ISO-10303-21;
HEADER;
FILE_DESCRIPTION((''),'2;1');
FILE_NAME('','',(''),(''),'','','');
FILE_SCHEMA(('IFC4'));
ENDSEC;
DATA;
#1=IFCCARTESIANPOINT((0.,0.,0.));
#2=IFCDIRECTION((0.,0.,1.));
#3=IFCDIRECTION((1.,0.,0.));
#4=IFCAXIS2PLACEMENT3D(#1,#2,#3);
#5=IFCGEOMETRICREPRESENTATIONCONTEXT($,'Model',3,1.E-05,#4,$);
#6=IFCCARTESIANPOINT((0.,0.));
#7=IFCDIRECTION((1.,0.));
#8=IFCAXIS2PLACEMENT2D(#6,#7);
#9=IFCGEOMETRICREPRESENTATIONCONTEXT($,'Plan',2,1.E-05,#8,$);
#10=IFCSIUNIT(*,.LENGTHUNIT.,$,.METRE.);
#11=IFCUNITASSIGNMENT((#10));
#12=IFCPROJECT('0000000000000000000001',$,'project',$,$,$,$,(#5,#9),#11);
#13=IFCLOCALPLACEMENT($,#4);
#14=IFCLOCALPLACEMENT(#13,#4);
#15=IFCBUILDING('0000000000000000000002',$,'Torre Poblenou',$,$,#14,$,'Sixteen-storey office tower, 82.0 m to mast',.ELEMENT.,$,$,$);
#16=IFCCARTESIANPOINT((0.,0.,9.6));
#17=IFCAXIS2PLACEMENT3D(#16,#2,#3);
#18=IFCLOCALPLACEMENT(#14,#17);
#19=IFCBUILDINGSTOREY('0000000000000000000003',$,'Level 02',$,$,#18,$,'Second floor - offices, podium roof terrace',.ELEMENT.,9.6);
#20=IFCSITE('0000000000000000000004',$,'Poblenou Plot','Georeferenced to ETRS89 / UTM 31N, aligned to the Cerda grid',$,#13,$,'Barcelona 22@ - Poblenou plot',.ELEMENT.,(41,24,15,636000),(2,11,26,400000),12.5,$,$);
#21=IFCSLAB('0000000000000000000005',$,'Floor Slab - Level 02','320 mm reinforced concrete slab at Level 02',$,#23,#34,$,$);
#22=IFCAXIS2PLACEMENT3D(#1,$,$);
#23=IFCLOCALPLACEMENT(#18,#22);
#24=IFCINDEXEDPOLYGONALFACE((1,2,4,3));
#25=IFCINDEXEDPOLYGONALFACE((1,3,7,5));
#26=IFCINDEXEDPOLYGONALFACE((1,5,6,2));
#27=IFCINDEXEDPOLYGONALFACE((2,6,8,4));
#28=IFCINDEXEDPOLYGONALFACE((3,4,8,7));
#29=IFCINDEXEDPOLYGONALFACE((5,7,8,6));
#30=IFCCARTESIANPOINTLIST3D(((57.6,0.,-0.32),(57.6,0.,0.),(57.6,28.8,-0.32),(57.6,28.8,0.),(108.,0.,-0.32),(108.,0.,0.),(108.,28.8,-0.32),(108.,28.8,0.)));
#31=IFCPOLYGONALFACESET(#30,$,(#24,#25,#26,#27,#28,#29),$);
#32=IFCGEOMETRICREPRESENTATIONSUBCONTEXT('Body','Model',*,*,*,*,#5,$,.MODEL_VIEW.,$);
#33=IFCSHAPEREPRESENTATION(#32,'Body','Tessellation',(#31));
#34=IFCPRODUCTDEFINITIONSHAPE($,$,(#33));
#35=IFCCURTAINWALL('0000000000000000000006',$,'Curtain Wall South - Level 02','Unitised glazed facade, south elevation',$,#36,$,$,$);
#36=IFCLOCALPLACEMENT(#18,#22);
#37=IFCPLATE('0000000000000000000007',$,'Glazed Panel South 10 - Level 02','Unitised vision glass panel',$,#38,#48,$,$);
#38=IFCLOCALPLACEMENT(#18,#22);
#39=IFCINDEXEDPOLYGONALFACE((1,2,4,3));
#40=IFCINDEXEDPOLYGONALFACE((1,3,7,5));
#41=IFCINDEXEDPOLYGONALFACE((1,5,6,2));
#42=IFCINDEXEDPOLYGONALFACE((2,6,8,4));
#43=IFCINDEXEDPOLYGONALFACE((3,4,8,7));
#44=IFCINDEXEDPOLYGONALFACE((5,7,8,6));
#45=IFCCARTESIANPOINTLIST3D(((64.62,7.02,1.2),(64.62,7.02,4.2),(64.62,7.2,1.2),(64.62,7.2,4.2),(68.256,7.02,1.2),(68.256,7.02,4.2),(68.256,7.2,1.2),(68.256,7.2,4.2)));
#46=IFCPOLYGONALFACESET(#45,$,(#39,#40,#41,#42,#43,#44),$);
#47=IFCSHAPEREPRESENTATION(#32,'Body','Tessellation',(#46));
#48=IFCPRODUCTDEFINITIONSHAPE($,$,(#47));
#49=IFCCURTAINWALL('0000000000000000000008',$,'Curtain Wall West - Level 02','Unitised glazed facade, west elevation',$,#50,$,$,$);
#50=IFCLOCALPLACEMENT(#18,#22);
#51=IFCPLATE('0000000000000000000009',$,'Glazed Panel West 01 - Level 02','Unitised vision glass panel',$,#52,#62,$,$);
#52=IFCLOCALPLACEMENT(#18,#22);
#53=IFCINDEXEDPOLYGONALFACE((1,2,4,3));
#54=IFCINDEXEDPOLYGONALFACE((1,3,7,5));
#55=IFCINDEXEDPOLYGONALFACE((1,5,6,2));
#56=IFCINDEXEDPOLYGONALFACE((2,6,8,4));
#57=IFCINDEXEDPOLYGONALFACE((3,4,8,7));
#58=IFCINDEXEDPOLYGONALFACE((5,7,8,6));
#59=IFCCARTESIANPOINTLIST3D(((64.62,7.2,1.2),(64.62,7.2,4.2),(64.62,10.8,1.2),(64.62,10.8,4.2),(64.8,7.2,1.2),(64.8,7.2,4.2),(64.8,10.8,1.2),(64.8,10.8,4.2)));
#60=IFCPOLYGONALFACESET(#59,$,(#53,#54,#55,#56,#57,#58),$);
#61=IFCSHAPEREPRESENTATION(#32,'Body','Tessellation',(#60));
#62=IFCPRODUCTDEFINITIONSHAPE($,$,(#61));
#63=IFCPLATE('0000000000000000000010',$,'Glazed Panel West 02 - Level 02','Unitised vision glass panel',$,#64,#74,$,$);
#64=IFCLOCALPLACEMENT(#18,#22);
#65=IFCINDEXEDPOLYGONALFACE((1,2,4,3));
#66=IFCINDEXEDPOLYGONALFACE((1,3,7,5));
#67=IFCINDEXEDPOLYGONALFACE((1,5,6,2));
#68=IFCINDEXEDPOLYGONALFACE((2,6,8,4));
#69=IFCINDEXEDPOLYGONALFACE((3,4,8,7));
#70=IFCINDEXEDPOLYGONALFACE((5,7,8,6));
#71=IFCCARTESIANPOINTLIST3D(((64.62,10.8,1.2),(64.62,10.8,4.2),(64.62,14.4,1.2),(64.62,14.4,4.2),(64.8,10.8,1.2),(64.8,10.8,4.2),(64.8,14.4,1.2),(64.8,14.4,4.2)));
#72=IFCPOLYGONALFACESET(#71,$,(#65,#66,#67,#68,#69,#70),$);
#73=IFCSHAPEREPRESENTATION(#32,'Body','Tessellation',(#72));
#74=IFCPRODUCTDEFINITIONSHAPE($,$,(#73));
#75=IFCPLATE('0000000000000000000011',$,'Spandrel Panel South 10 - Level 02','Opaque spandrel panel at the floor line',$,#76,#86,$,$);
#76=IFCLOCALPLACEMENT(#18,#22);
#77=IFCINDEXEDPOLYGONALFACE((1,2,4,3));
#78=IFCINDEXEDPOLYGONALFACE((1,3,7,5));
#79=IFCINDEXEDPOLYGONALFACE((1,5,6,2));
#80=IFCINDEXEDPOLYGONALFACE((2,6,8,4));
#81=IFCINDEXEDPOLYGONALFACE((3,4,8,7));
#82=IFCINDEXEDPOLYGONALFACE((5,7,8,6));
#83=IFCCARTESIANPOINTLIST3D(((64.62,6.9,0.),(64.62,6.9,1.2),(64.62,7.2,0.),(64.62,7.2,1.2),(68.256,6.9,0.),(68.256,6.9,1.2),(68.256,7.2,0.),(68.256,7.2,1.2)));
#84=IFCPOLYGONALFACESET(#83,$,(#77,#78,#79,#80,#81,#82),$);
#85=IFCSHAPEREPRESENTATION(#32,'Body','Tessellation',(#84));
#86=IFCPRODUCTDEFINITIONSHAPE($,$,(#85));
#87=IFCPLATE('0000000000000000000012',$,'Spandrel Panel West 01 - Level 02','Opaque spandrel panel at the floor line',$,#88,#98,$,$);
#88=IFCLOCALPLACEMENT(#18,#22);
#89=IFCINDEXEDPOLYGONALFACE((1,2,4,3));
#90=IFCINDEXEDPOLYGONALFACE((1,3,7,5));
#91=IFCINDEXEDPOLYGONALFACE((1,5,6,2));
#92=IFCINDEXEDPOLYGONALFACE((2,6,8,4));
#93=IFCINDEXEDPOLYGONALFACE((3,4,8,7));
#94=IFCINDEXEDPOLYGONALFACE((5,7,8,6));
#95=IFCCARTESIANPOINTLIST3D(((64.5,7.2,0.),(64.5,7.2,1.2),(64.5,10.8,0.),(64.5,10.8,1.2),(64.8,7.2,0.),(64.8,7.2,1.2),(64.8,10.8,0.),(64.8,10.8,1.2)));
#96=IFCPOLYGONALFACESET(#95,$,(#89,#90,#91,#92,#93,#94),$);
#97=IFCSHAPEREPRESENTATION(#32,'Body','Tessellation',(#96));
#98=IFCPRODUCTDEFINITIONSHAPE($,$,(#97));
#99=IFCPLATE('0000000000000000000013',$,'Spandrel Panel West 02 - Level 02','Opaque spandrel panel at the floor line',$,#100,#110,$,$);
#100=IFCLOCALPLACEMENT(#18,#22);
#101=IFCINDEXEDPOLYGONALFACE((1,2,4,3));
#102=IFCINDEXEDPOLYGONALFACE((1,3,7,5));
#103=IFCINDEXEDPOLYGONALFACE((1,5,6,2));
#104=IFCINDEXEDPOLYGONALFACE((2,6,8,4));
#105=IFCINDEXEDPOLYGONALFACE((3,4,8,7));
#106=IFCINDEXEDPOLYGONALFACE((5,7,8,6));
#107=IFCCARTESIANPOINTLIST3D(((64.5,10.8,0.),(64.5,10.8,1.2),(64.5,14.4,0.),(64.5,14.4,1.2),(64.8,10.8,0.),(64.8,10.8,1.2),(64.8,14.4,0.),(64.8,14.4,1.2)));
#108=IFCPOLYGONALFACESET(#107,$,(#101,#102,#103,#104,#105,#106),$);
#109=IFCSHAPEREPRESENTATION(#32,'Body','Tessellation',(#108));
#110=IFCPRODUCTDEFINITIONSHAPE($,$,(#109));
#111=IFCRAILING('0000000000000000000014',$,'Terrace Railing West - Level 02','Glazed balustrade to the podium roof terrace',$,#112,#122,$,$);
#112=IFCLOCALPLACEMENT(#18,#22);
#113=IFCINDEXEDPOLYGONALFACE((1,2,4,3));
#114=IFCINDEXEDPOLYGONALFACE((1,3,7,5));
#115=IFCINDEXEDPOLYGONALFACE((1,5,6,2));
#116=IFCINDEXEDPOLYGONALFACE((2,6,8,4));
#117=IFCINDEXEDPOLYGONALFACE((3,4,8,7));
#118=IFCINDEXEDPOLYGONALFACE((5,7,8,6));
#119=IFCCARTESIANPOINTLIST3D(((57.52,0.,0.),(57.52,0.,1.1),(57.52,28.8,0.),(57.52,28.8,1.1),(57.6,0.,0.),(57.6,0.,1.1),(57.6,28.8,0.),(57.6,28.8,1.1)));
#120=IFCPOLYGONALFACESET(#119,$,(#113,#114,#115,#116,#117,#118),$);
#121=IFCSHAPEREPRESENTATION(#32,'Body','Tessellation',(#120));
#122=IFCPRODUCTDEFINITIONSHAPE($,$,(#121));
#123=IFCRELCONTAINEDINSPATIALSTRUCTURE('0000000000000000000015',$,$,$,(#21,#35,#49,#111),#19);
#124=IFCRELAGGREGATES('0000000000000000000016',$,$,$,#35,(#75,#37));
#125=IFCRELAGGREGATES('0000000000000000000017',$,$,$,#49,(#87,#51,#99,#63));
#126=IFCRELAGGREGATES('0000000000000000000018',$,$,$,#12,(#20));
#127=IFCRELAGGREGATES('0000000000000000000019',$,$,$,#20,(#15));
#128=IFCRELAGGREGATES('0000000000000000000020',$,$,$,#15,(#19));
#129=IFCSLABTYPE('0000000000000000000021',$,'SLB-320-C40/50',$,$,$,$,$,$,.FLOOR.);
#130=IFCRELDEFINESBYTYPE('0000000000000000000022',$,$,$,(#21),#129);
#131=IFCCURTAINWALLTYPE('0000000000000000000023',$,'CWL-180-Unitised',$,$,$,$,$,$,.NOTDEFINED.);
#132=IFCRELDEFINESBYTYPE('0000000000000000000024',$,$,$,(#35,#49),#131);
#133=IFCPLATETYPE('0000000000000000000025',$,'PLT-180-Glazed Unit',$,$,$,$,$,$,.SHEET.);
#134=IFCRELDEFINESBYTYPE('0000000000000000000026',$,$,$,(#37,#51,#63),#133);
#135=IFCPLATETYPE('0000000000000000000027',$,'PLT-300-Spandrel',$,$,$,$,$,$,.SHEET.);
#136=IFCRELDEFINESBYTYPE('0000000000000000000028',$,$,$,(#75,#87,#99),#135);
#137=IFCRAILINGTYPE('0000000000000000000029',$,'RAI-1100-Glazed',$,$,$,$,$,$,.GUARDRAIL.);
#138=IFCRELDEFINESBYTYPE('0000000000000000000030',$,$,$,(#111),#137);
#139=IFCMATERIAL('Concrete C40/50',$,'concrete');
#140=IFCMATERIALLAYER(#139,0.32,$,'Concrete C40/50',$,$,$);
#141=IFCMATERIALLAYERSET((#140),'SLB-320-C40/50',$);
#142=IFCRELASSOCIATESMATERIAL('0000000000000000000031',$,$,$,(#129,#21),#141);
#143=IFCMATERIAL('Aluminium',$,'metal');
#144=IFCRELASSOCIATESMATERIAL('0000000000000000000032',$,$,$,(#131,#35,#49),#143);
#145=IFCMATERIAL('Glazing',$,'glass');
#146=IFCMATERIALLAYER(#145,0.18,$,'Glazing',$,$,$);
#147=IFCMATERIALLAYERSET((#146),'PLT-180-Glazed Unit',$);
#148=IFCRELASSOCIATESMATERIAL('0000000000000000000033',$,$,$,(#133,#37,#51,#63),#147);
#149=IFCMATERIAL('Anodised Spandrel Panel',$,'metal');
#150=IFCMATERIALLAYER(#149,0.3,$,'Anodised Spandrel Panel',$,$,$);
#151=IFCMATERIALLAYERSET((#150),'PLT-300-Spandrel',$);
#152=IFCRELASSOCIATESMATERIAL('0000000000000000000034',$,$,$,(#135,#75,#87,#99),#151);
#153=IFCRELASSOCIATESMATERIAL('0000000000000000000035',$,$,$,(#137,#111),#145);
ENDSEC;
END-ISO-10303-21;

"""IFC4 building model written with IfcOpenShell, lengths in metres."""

from ifc_helpers import new_model, si_unit, frame, origin_with_axes, origin_2d_with_axis, place, context, subcontext, project, spatial, line, indexed_curve, outline, extrude, material, layer, layer_set, layer_usage, type_object, element, aggregate, save


model = new_model("IFC4")

# Units and contexts
model_context = context("Model", 3, precision=1e-05, world=origin_with_axes())
plan_context = context("Plan", 2, precision=1e-05, world=origin_2d_with_axis())
body_context = subcontext(model_context, "Body", "Model", "MODEL_VIEW")
ifc_project = project(units=[si_unit("LENGTHUNIT", "METRE")], contexts=[model_context, plan_context])

# Site, building, storey
site_placement = place(None, origin_with_axes())
site = spatial("IfcSite", under=ifc_project, at=site_placement, Name="Poblenou Plot", Description="Georeferenced to ETRS89 / UTM 31N, aligned to the Cerda grid", LongName="Barcelona 22@ - Poblenou plot", CompositionType="ELEMENT", RefLatitude=(41, 24, 15, 636000), RefLongitude=(2, 11, 26, 400000), RefElevation=12.5)
building_placement = place(site_placement, origin_with_axes())
building = spatial("IfcBuilding", under=site, at=building_placement, Name="Torre Poblenou", LongName="Sixteen-storey office tower, 82.0 m to mast", CompositionType="ELEMENT")
storey_placement = place(building_placement, frame((0.0, 0.0, 9.6), z_axis=(0.0, 0.0, 1.0), x_axis=(1.0, 0.0, 0.0)))
storey = spatial("IfcBuildingStorey", under=building, at=storey_placement, Name="Level 02", LongName="Second floor - offices, podium roof terrace", CompositionType="ELEMENT", Elevation=9.6)

# Shared definitions
ifc_material_1 = material(Name="Concrete C40/50", Category="concrete")

# Shared definitions
ifc_material_2 = material(Name="Aluminium", Category="metal")

# Slab
ifc_layer_1 = layer(ifc_material_1, 0.32, Name="Concrete C40/50")
ifc_layer_set_1 = layer_set([ifc_layer_1], Name="SLB-320-C40/50")
ifc_layer_usage_1 = layer_usage(ifc_layer_set_1, "AXIS3", "POSITIVE", 0.0)
slab_type = type_object("IfcSlabType", Name="SLB-320-C40/50", PredefinedType="FLOOR", material=ifc_layer_set_1)
slab_placement = place(storey_placement, frame((57.6, 0.0, -0.32), z_axis=(0.0, 0.0, 1.0), x_axis=(1.0, 0.0, 0.0)))
element("IfcSlab", 1, at=slab_placement, inside=storey, type_object=slab_type, material=ifc_layer_usage_1, Name="Floor Slab - Level 02", Description="320 mm reinforced concrete slab at Level 02", context=body_context, shape_type="SweptSolid", body=[
    extrude(outline(indexed_curve([(0.0, 0.0), (50.4, 0.0), (50.4, 28.8), (0.0, 28.8)], segments=[line(1, 2, 3, 4, 1)])), origin_with_axes(), (0.0, 0.0, 1.0), 0.32),
])

# Curtain wall, plate
curtain_wall_type = type_object("IfcCurtainWallType", Name="CWL-180-Unitised", PredefinedType="NOTDEFINED", material=ifc_material_2)
curtain_wall_1_placement = place(storey_placement, frame((100.98, 7.2, 0.0), z_axis=(0.0, 0.0, 1.0), x_axis=(-1.0, 0.0, 0.0)))
curtain_wall_1 = element("IfcCurtainWall", 2, at=curtain_wall_1_placement, inside=storey, type_object=curtain_wall_type, material=ifc_material_2, Name="Curtain Wall South - Level 02", Description="Unitised glazed facade, south elevation")
ifc_material_3 = material(Name="Glazing", Category="glass")
ifc_layer_2 = layer(ifc_material_3, 0.18, Name="Glazing")
ifc_layer_set_2 = layer_set([ifc_layer_2], Name="PLT-180-Glazed Unit")
ifc_layer_usage_2 = layer_usage(ifc_layer_set_2, "AXIS2", "POSITIVE", 0.0)
plate_type_1 = type_object("IfcPlateType", Name="PLT-180-Glazed Unit", PredefinedType="SHEET", material=ifc_layer_set_2)
plate_1_placement = place(curtain_wall_1_placement, frame((32.724, 0.0, 1.2), z_axis=(0.0, 0.0, 1.0), x_axis=(1.0, 0.0, 0.0)))
plate_1 = element("IfcPlate", 3, at=plate_1_placement, type_object=plate_type_1, material=ifc_layer_usage_2, Name="Glazed Panel South 10 - Level 02", Description="Unitised vision glass panel", context=body_context, shape_type="SweptSolid", body=[
    extrude(outline(indexed_curve([(0.0, 0.0), (3.636, 0.0), (3.636, 0.18), (0.0, 0.18)], segments=[line(1, 2, 3, 4, 1)])), origin_with_axes(), (0.0, 0.0, 1.0), 3.0),
])

# Curtain wall, plates
curtain_wall_2_placement = place(storey_placement, frame((64.8, 7.2, 0.0), z_axis=(0.0, 0.0, 1.0), x_axis=(0.0, 1.0, 0.0)))
curtain_wall_2 = element("IfcCurtainWall", 4, at=curtain_wall_2_placement, inside=storey, type_object=curtain_wall_type, material=ifc_material_2, Name="Curtain Wall West - Level 02", Description="Unitised glazed facade, west elevation")
ifc_layer_usage_3 = layer_usage(ifc_layer_set_2, "AXIS2", "POSITIVE", 0.0)
plate_2_placement = place(curtain_wall_2_placement, frame((0.0, 0.0, 1.2), z_axis=(0.0, 0.0, 1.0), x_axis=(1.0, 0.0, 0.0)))
plate_2 = element("IfcPlate", 5, at=plate_2_placement, type_object=plate_type_1, material=ifc_layer_usage_3, Name="Glazed Panel West 01 - Level 02", Description="Unitised vision glass panel", context=body_context, shape_type="SweptSolid", body=[
    extrude(outline(indexed_curve([(0.0, 0.0), (3.6, 0.0), (3.6, 0.18), (0.0, 0.18)], segments=[line(1, 2, 3, 4, 1)])), origin_with_axes(), (0.0, 0.0, 1.0), 3.0),
])
ifc_layer_usage_4 = layer_usage(ifc_layer_set_2, "AXIS2", "POSITIVE", 0.0)
plate_3_placement = place(curtain_wall_2_placement, frame((3.6, 0.0, 1.2), z_axis=(0.0, 0.0, 1.0), x_axis=(1.0, 0.0, 0.0)))
plate_3 = element("IfcPlate", 6, at=plate_3_placement, type_object=plate_type_1, material=ifc_layer_usage_4, Name="Glazed Panel West 02 - Level 02", Description="Unitised vision glass panel", context=body_context, shape_type="SweptSolid", body=[
    extrude(outline(indexed_curve([(0.0, 0.0), (3.6, 0.0), (3.6, 0.18), (0.0, 0.18)], segments=[line(1, 2, 3, 4, 1)])), origin_with_axes(), (0.0, 0.0, 1.0), 3.0),
])

# Plates
ifc_material_4 = material(Name="Anodised Spandrel Panel", Category="metal")
ifc_layer_3 = layer(ifc_material_4, 0.3, Name="Anodised Spandrel Panel")
ifc_layer_set_3 = layer_set([ifc_layer_3], Name="PLT-300-Spandrel")
ifc_layer_usage_5 = layer_usage(ifc_layer_set_3, "AXIS2", "POSITIVE", 0.0)
plate_type_2 = type_object("IfcPlateType", Name="PLT-300-Spandrel", PredefinedType="SHEET", material=ifc_layer_set_3)
plate_4_placement = place(curtain_wall_1_placement, frame((32.724, 0.0, 0.0), z_axis=(0.0, 0.0, 1.0), x_axis=(1.0, 0.0, 0.0)))
plate_4 = element("IfcPlate", 7, at=plate_4_placement, type_object=plate_type_2, material=ifc_layer_usage_5, Name="Spandrel Panel South 10 - Level 02", Description="Opaque spandrel panel at the floor line", context=body_context, shape_type="SweptSolid", body=[
    extrude(outline(indexed_curve([(0.0, 0.0), (3.636, 0.0), (3.636, 0.3), (0.0, 0.3)], segments=[line(1, 2, 3, 4, 1)])), origin_with_axes(), (0.0, 0.0, 1.0), 1.2),
])
aggregate(curtain_wall_1, [plate_4, plate_1])
ifc_layer_usage_6 = layer_usage(ifc_layer_set_3, "AXIS2", "POSITIVE", 0.0)
plate_5_placement = place(curtain_wall_2_placement, origin_with_axes())
plate_5 = element("IfcPlate", 8, at=plate_5_placement, type_object=plate_type_2, material=ifc_layer_usage_6, Name="Spandrel Panel West 01 - Level 02", Description="Opaque spandrel panel at the floor line", context=body_context, shape_type="SweptSolid", body=[
    extrude(outline(indexed_curve([(0.0, 0.0), (3.6, 0.0), (3.6, 0.3), (0.0, 0.3)], segments=[line(1, 2, 3, 4, 1)])), origin_with_axes(), (0.0, 0.0, 1.0), 1.2),
])
ifc_layer_usage_7 = layer_usage(ifc_layer_set_3, "AXIS2", "POSITIVE", 0.0)
plate_6_placement = place(curtain_wall_2_placement, frame((3.6, 0.0, 0.0), z_axis=(0.0, 0.0, 1.0), x_axis=(1.0, 0.0, 0.0)))
plate_6 = element("IfcPlate", 9, at=plate_6_placement, type_object=plate_type_2, material=ifc_layer_usage_7, Name="Spandrel Panel West 02 - Level 02", Description="Opaque spandrel panel at the floor line", context=body_context, shape_type="SweptSolid", body=[
    extrude(outline(indexed_curve([(0.0, 0.0), (3.6, 0.0), (3.6, 0.3), (0.0, 0.3)], segments=[line(1, 2, 3, 4, 1)])), origin_with_axes(), (0.0, 0.0, 1.0), 1.2),
])
aggregate(curtain_wall_2, [plate_5, plate_2, plate_6, plate_3])

# Railing
railing_type = type_object("IfcRailingType", Name="RAI-1100-Glazed", PredefinedType="GUARDRAIL", material=ifc_material_3)
railing_placement = place(storey_placement, frame((57.6, 0.0, 0.0), z_axis=(0.0, 0.0, 1.0), x_axis=(0.0, 1.0, 0.0)))
element("IfcRailing", 10, at=railing_placement, inside=storey, type_object=railing_type, material=ifc_material_3, Name="Terrace Railing West - Level 02", Description="Glazed balustrade to the podium roof terrace", context=body_context, shape_type="SweptSolid", body=[
    extrude(outline(indexed_curve([(0.0, 0.0), (28.8, 0.0), (28.8, 0.08), (0.0, 0.08)], segments=[line(1, 2, 3, 4, 1)])), origin_with_axes(), (0.0, 0.0, 1.0), 1.1),
])

save(model, "model.ifc")
